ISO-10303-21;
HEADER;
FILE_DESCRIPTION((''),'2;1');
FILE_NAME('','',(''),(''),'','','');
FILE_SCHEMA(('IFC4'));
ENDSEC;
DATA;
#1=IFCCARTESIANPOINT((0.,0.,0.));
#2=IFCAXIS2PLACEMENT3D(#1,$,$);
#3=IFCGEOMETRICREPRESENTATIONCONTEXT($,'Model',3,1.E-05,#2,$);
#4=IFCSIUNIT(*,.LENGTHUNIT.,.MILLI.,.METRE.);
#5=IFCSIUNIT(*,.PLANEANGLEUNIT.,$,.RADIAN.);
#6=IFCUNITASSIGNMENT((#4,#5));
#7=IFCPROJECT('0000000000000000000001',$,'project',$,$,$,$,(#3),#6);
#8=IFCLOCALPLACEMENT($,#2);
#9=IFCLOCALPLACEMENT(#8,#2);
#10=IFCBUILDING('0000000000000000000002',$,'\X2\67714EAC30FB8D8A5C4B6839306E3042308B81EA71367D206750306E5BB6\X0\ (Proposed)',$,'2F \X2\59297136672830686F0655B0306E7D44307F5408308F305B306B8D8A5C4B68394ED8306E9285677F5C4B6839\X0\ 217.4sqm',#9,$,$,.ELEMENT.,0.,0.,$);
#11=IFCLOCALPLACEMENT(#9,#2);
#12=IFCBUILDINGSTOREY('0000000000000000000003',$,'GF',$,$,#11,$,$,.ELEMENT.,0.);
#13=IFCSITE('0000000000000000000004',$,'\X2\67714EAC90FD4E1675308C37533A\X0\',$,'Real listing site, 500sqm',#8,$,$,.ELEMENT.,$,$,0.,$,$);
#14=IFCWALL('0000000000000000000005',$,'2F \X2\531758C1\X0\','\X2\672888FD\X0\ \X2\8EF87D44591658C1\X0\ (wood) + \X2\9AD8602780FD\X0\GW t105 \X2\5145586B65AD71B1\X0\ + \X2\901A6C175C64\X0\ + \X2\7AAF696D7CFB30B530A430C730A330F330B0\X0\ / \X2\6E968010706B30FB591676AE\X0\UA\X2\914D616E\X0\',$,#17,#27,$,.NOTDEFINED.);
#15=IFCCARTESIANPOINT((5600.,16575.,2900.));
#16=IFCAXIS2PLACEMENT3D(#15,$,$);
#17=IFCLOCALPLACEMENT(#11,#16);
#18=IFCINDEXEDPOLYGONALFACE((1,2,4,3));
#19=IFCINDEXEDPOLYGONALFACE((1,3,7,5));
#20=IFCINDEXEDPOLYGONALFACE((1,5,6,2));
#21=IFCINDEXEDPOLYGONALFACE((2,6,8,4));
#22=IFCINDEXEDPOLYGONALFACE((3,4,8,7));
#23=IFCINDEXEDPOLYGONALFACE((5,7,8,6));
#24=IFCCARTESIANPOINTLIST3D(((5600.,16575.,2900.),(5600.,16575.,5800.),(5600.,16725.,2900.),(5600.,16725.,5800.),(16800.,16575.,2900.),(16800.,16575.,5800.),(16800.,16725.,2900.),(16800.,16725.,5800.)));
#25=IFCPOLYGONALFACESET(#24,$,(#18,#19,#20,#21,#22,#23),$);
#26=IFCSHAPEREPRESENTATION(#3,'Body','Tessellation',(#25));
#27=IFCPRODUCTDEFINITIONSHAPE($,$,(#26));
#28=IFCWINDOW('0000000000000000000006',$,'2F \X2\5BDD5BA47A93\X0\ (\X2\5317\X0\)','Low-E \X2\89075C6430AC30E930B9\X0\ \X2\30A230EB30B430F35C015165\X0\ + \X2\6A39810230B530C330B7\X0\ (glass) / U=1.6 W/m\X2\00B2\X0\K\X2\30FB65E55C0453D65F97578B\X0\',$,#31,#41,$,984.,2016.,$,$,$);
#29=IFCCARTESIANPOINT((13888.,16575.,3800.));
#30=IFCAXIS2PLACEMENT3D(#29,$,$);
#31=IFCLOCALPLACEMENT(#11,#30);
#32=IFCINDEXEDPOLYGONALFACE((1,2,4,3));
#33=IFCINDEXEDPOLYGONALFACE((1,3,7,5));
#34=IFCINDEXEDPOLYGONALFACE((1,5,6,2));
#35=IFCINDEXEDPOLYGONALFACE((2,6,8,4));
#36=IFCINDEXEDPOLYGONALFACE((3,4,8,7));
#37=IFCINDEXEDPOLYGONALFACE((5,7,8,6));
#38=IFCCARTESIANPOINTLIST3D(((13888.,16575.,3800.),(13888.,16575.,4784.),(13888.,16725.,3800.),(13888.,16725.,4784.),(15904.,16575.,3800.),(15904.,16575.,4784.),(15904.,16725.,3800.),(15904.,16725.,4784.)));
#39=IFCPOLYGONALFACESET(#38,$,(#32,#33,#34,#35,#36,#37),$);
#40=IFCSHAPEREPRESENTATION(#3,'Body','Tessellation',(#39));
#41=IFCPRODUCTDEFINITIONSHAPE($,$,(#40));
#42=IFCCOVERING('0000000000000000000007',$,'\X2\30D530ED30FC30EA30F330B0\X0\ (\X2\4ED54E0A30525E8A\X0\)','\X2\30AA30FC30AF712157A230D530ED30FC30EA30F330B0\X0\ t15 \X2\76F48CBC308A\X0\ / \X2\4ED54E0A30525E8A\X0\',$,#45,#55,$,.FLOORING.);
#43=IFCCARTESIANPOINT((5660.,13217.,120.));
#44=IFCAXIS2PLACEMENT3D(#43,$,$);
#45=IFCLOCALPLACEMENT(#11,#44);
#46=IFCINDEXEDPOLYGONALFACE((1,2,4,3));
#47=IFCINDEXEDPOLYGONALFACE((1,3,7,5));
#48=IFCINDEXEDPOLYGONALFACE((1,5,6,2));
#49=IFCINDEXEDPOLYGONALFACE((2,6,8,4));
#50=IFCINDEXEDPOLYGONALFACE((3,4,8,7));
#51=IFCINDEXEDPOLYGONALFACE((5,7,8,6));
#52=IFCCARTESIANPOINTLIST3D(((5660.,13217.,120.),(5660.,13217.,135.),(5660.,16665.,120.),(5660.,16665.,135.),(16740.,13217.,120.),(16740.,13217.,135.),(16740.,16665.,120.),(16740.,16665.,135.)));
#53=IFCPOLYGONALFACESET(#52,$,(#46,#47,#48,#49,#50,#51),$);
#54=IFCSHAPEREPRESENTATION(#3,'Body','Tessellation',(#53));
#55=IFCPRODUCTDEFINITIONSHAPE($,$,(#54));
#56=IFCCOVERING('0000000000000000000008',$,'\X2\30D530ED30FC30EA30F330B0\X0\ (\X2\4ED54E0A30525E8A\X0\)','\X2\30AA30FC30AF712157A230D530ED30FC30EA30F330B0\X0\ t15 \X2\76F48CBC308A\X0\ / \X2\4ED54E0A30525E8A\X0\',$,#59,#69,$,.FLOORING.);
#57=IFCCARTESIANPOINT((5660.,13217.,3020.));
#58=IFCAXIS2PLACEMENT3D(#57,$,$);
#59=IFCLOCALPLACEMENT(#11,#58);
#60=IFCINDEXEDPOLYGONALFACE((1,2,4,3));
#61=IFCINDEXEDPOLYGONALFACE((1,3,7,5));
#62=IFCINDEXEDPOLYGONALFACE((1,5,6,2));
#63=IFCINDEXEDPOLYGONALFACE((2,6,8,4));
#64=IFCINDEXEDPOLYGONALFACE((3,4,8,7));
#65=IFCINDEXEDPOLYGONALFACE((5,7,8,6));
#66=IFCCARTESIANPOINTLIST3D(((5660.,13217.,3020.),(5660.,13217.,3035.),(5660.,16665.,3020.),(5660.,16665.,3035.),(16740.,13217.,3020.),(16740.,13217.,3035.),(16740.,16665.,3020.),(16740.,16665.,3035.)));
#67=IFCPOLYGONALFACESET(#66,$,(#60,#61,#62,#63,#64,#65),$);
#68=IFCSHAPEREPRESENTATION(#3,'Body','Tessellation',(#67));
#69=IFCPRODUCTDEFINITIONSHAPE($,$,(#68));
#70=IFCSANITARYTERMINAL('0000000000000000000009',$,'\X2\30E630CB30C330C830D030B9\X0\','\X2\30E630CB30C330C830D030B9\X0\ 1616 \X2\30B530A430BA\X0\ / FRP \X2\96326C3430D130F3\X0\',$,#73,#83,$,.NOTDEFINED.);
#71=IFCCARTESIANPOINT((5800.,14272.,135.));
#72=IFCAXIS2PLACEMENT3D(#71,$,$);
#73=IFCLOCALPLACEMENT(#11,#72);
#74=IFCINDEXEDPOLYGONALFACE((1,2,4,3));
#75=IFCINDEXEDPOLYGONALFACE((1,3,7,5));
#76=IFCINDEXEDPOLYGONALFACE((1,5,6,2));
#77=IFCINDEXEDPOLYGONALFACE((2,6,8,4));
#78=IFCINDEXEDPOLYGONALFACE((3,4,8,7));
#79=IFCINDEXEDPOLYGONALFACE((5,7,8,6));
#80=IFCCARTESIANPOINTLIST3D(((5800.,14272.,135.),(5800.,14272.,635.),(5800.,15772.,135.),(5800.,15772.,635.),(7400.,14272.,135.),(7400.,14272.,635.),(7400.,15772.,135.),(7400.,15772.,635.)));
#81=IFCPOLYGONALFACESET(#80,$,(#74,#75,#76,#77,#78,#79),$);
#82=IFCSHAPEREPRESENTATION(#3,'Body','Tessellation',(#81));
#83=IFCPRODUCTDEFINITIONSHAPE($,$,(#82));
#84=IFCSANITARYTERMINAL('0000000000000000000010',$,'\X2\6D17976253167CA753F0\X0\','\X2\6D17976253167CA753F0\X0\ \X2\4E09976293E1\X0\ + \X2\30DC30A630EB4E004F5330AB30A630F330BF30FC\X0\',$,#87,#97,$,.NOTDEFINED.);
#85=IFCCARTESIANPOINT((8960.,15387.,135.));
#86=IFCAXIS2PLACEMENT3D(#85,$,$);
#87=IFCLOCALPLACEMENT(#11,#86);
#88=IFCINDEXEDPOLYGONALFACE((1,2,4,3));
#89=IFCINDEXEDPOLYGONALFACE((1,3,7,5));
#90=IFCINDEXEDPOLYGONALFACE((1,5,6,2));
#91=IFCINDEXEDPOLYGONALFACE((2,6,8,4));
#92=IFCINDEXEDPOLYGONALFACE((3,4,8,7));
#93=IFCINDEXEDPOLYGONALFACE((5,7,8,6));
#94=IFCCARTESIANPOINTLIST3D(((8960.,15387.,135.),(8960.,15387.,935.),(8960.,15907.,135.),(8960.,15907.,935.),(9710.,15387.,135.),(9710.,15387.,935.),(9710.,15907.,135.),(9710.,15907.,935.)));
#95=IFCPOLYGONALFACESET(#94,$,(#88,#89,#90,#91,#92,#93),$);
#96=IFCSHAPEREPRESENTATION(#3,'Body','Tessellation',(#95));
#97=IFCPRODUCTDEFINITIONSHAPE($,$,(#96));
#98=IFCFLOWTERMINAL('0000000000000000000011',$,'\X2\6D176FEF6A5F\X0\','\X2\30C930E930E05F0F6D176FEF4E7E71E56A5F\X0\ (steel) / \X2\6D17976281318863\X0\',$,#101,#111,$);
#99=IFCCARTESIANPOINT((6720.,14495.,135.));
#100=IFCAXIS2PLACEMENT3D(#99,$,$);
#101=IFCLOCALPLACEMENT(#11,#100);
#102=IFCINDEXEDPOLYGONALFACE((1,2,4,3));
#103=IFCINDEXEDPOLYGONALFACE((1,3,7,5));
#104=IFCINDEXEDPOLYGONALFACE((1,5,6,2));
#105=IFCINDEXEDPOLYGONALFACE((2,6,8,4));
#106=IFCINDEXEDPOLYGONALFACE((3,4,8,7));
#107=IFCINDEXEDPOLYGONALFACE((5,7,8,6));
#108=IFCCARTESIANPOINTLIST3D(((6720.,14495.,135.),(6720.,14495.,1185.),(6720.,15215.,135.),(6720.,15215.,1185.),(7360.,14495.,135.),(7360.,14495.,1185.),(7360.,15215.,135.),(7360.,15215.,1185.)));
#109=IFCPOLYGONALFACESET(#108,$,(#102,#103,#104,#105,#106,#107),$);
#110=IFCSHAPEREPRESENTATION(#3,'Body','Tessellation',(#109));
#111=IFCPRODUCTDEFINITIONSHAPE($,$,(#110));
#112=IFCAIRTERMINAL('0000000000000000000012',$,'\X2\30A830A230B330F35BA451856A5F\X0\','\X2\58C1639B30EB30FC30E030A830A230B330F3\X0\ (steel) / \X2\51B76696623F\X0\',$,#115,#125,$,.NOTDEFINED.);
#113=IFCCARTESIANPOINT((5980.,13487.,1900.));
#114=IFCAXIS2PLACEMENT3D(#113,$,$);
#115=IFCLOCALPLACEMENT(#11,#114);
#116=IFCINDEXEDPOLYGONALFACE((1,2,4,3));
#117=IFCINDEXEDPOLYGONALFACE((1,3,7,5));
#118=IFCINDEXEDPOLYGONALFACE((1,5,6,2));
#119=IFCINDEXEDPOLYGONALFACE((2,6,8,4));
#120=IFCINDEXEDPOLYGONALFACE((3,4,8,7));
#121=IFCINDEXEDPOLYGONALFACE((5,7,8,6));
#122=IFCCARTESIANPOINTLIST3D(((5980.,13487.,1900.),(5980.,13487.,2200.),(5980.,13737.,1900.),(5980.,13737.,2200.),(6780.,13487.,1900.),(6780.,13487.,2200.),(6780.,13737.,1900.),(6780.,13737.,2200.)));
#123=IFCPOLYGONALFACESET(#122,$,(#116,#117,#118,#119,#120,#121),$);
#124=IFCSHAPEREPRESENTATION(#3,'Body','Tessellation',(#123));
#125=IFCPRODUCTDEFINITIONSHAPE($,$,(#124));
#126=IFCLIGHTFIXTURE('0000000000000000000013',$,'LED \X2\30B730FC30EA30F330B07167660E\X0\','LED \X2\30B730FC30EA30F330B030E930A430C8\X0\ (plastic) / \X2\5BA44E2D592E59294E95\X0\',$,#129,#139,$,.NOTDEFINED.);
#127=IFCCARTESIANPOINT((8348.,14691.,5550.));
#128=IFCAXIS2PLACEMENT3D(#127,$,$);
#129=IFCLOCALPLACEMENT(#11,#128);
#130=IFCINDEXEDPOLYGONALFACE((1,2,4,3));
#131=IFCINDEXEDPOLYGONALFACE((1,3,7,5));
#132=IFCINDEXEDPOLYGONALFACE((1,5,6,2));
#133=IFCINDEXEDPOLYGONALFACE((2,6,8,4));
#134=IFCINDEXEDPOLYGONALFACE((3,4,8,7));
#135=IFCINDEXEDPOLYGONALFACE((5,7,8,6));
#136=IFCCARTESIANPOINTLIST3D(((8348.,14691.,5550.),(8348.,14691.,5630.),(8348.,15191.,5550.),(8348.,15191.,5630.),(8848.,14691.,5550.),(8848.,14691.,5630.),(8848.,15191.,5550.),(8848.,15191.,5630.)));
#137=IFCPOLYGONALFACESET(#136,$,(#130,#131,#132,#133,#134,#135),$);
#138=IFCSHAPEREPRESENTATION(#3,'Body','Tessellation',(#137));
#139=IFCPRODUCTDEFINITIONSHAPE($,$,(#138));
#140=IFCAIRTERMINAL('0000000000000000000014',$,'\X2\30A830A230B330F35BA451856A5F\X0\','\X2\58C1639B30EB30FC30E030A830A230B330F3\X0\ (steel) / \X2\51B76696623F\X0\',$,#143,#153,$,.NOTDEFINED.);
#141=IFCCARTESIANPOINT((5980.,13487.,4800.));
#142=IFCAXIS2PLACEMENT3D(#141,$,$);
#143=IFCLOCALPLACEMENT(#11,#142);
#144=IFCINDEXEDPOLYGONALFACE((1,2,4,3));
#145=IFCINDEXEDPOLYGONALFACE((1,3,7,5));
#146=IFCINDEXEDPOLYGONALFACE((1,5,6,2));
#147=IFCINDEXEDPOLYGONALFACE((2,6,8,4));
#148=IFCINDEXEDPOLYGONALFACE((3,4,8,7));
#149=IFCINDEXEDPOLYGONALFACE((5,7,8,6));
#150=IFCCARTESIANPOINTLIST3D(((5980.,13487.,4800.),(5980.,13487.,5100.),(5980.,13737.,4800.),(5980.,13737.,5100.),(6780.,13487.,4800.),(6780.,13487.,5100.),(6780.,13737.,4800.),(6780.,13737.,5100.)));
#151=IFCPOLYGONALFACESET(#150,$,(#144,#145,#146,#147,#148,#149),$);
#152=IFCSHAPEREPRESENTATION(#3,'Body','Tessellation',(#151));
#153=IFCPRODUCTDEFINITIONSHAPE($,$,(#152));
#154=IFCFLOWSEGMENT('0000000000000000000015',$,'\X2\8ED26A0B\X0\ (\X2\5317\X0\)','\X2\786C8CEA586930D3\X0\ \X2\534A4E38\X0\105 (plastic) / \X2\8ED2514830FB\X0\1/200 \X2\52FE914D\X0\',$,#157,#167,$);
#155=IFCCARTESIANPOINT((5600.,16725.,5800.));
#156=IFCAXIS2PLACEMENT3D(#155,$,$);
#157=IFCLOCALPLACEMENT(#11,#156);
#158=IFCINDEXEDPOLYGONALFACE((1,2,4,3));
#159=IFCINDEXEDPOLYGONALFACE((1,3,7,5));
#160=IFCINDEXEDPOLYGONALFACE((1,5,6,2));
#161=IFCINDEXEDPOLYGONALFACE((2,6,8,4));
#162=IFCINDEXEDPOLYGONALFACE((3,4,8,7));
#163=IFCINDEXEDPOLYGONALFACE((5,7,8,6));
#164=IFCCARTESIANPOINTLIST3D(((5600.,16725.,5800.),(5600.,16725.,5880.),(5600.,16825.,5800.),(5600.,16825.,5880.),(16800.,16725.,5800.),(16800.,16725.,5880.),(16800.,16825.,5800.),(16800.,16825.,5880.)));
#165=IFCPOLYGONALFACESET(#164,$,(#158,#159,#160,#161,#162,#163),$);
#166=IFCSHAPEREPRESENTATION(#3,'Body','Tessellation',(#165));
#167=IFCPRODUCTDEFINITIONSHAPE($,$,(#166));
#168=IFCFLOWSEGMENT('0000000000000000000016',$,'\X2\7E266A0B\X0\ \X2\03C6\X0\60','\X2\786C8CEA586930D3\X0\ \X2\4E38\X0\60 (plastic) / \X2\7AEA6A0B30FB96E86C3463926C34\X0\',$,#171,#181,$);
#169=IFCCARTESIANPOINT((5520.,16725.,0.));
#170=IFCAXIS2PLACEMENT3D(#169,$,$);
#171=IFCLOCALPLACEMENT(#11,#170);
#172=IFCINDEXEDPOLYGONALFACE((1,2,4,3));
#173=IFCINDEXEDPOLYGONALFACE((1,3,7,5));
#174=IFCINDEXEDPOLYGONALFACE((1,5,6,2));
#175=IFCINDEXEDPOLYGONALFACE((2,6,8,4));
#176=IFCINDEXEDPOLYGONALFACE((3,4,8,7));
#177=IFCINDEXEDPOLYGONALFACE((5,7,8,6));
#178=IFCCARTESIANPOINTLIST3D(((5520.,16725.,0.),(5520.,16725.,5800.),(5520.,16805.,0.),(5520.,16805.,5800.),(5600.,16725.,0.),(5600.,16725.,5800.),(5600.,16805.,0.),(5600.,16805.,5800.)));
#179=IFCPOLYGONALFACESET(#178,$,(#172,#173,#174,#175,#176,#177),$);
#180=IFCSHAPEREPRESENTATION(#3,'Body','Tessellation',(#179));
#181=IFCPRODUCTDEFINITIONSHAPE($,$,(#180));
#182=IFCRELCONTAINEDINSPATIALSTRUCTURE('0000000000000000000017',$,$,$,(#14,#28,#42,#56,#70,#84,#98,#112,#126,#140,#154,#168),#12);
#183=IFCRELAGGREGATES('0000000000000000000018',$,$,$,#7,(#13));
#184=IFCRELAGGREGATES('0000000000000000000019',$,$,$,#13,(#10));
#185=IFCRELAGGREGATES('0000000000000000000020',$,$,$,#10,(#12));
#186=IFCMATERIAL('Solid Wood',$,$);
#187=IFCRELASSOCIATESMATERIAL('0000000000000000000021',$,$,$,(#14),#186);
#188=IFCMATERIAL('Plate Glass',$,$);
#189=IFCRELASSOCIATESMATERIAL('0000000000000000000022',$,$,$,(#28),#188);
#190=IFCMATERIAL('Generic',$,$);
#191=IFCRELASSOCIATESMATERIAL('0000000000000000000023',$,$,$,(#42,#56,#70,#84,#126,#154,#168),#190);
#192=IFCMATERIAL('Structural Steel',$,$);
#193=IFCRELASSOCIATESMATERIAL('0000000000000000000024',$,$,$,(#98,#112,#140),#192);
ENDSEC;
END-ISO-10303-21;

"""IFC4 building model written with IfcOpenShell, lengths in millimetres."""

from ifc_helpers import new_model, si_unit, frame, frame_2d, origin, place, context, project, spatial, rectangle, extrude, material, element, fill, save


model = new_model("IFC4")

# Units and contexts
model_context = context("Model", 3, precision=1e-05, world=origin())
ifc_project = project(units=[si_unit("LENGTHUNIT", "METRE", prefix="MILLI"), si_unit("PLANEANGLEUNIT", "RADIAN")], contexts=[model_context])

# Site, building, storey
site_placement = place(None, origin())
site = spatial("IfcSite", under=ifc_project, at=site_placement, Name="東京都世田谷区", ObjectType="Real listing site, 500sqm", CompositionType="ELEMENT", RefElevation=0.0)
building_placement = place(site_placement, origin())
building = spatial("IfcBuilding", under=site, at=building_placement, Name="東京・越屋根のある自然素材の家 (Proposed)", ObjectType="2F 天然木と漆喰の組み合わせに越屋根付の銅板屋根 217.4sqm", CompositionType="ELEMENT", ElevationOfRefHeight=0.0, ElevationOfTerrain=0.0)
storey_placement = place(building_placement, origin())
storey = spatial("IfcBuildingStorey", under=building, at=storey_placement, Name="GF", CompositionType="ELEMENT", Elevation=0.0)

# Shared definitions
ifc_material_1 = material(Name="Solid Wood")

# Shared definitions
ifc_material_2 = material(Name="Plate Glass")

# Wall, opening, window
wall_1_placement = place(storey_placement, frame((5600.0, 16575.0, 2900.0)))
wall_1 = element("IfcWall", 1, at=wall_1_placement, inside=storey, material=ifc_material_1, Name="2F 北壁", Description="木製 軸組外壁 (wood) + 高性能GW t105 充填断熱 + 通気層 + 窯業系サイディング / 準耐火・外皮UA配慮", PredefinedType="NOTDEFINED", context=model_context, shape_type="SweptSolid", body=[
    extrude(rectangle(XDim=11200.0, YDim=150.0, at=frame_2d((5600.0, 75.0))), frame((5600.0, 16575.0, 2900.0)), (0.0, 0.0, 1.0), 2900.0),
])
opening_1_placement = place(storey_placement, frame((13888.0, 16575.0, 3800.0)))
opening_1 = element("IfcOpeningElement", 2, at=opening_1_placement, cuts=wall_1, PredefinedType="NOTDEFINED", context=model_context, shape_type="SweptSolid", body=[
    extrude(rectangle(XDim=2016.0, YDim=150.0, at=frame_2d((1008.0, 75.0))), frame((13888.0, 16575.0, 3800.0)), (0.0, 0.0, 1.0), 984.0),
])
window_1_placement = place(storey_placement, frame((13888.0, 16575.0, 3800.0)))
window_1 = element("IfcWindow", 3, at=window_1_placement, inside=storey, material=ifc_material_2, Name="2F 寝室窓 (北)", Description="Low-E 複層ガラス アルゴン封入 + 樹脂サッシ (glass) / U=1.6 W/m²K・日射取得型", OverallHeight=984.0, OverallWidth=2016.0, context=model_context, shape_type="SweptSolid", body=[
    extrude(rectangle(XDim=2016.0, YDim=150.0, at=frame_2d((1008.0, 75.0))), frame((13888.0, 16575.0, 3800.0)), (0.0, 0.0, 1.0), 984.0),
])
fill(opening_1, window_1)

# Coverings
ifc_material_3 = material(Name="Generic")
covering_1_placement = place(storey_placement, frame((5660.0, 13217.0, 120.0)))
element("IfcCovering", 4, at=covering_1_placement, inside=storey, material=ifc_material_3, Name="フローリング (仕上げ床)", Description="オーク無垢フローリング t15 直貼り / 仕上げ床", PredefinedType="FLOORING", context=model_context, shape_type="SweptSolid", body=[
    extrude(rectangle(XDim=11080.0, YDim=3448.0, at=frame_2d((5540.0, 1724.0))), frame((5660.0, 13217.0, 120.0)), (0.0, 0.0, 1.0), 15.0),
])
covering_2_placement = place(storey_placement, frame((5660.0, 13217.0, 3020.0)))
element("IfcCovering", 5, at=covering_2_placement, inside=storey, material=ifc_material_3, Name="フローリング (仕上げ床)", Description="オーク無垢フローリング t15 直貼り / 仕上げ床", PredefinedType="FLOORING", context=model_context, shape_type="SweptSolid", body=[
    extrude(rectangle(XDim=11080.0, YDim=3448.0, at=frame_2d((5540.0, 1724.0))), frame((5660.0, 13217.0, 3020.0)), (0.0, 0.0, 1.0), 15.0),
])

# Sanitary terminals
sanitary_terminal_1_placement = place(storey_placement, frame((5800.0, 14272.0, 135.0)))
element("IfcSanitaryTerminal", 6, at=sanitary_terminal_1_placement, inside=storey, material=ifc_material_3, Name="ユニットバス", Description="ユニットバス 1616 サイズ / FRP 防水パン", PredefinedType="NOTDEFINED", context=model_context, shape_type="SweptSolid", body=[
    extrude(rectangle(XDim=1600.0, YDim=1500.0, at=frame_2d((800.0, 750.0))), frame((5800.0, 14272.0, 135.0)), (0.0, 0.0, 1.0), 500.0),
])
sanitary_terminal_2_placement = place(storey_placement, frame((8960.0, 15387.0, 135.0)))
element("IfcSanitaryTerminal", 7, at=sanitary_terminal_2_placement, inside=storey, material=ifc_material_3, Name="洗面化粧台", Description="洗面化粧台 三面鏡 + ボウル一体カウンター", PredefinedType="NOTDEFINED", context=model_context, shape_type="SweptSolid", body=[
    extrude(rectangle(XDim=750.0, YDim=520.0, at=frame_2d((375.0, 260.0))), frame((8960.0, 15387.0, 135.0)), (0.0, 0.0, 1.0), 800.0),
])

# Flow terminal
ifc_material_4 = material(Name="Structural Steel")
flow_terminal_placement = place(storey_placement, frame((6720.0, 14495.0, 135.0)))
element("IfcFlowTerminal", 8, at=flow_terminal_placement, inside=storey, material=ifc_material_4, Name="洗濯機", Description="ドラム式洗濯乾燥機 (steel) / 洗面脱衣", context=model_context, shape_type="SweptSolid", body=[
    extrude(rectangle(XDim=640.0, YDim=720.0, at=frame_2d((320.0, 360.0))), frame((6720.0, 14495.0, 135.0)), (0.0, 0.0, 1.0), 1050.0),
])

# Air terminal
air_terminal_1_placement = place(storey_placement, frame((5980.0, 13487.0, 1900.0)))
element("IfcAirTerminal", 9, at=air_terminal_1_placement, inside=storey, material=ifc_material_4, Name="エアコン室内機", Description="壁掛ルームエアコン (steel) / 冷暖房", PredefinedType="NOTDEFINED", context=model_context, shape_type="SweptSolid", body=[
    extrude(rectangle(XDim=800.0, YDim=250.0, at=frame_2d((400.0, 125.0))), frame((5980.0, 13487.0, 1900.0)), (0.0, 0.0, 1.0), 300.0),
])

# Light fixture
light_fixture_placement = place(storey_placement, frame((8348.0, 14691.0, 5550.0)))
element("IfcLightFixture", 10, at=light_fixture_placement, inside=storey, material=ifc_material_3, Name="LED シーリング照明", Description="LED シーリングライト (plastic) / 室中央天井", PredefinedType="NOTDEFINED", context=model_context, shape_type="SweptSolid", body=[
    extrude(rectangle(XDim=500.0, YDim=500.0, at=frame_2d((250.0, 250.0))), frame((8348.0, 14691.0, 5550.0)), (0.0, 0.0, 1.0), 80.0),
])

# Air terminal
air_terminal_2_placement = place(storey_placement, frame((5980.0, 13487.0, 4800.0)))
element("IfcAirTerminal", 11, at=air_terminal_2_placement, inside=storey, material=ifc_material_4, Name="エアコン室内機", Description="壁掛ルームエアコン (steel) / 冷暖房", PredefinedType="NOTDEFINED", context=model_context, shape_type="SweptSolid", body=[
    extrude(rectangle(XDim=800.0, YDim=250.0, at=frame_2d((400.0, 125.0))), frame((5980.0, 13487.0, 4800.0)), (0.0, 0.0, 1.0), 300.0),
])

# Flow segments
flow_segment_1_placement = place(storey_placement, frame((5600.0, 16725.0, 5800.0)))
element("IfcFlowSegment", 12, at=flow_segment_1_placement, inside=storey, material=ifc_material_3, Name="軒樋 (北)", Description="硬質塩ビ 半丸105 (plastic) / 軒先・1/200 勾配", context=model_context, shape_type="SweptSolid", body=[
    extrude(rectangle(XDim=11200.0, YDim=100.0, at=frame_2d((5600.0, 50.0))), frame((5600.0, 16725.0, 5800.0)), (0.0, 0.0, 1.0), 80.0),
])
flow_segment_2_placement = place(storey_placement, frame((5520.0, 16725.0, 0.0)))
element("IfcFlowSegment", 13, at=flow_segment_2_placement, inside=storey, material=ifc_material_3, Name="縦樋 φ60", Description="硬質塩ビ 丸60 (plastic) / 竪樋・雨水排水", context=model_context, shape_type="SweptSolid", body=[
    extrude(rectangle(XDim=80.0, YDim=80.0, at=frame_2d((40.0, 40.0))), frame((5520.0, 16725.0, 0.0)), (0.0, 0.0, 1.0), 5800.0),
])

save(model, "model.ifc")
